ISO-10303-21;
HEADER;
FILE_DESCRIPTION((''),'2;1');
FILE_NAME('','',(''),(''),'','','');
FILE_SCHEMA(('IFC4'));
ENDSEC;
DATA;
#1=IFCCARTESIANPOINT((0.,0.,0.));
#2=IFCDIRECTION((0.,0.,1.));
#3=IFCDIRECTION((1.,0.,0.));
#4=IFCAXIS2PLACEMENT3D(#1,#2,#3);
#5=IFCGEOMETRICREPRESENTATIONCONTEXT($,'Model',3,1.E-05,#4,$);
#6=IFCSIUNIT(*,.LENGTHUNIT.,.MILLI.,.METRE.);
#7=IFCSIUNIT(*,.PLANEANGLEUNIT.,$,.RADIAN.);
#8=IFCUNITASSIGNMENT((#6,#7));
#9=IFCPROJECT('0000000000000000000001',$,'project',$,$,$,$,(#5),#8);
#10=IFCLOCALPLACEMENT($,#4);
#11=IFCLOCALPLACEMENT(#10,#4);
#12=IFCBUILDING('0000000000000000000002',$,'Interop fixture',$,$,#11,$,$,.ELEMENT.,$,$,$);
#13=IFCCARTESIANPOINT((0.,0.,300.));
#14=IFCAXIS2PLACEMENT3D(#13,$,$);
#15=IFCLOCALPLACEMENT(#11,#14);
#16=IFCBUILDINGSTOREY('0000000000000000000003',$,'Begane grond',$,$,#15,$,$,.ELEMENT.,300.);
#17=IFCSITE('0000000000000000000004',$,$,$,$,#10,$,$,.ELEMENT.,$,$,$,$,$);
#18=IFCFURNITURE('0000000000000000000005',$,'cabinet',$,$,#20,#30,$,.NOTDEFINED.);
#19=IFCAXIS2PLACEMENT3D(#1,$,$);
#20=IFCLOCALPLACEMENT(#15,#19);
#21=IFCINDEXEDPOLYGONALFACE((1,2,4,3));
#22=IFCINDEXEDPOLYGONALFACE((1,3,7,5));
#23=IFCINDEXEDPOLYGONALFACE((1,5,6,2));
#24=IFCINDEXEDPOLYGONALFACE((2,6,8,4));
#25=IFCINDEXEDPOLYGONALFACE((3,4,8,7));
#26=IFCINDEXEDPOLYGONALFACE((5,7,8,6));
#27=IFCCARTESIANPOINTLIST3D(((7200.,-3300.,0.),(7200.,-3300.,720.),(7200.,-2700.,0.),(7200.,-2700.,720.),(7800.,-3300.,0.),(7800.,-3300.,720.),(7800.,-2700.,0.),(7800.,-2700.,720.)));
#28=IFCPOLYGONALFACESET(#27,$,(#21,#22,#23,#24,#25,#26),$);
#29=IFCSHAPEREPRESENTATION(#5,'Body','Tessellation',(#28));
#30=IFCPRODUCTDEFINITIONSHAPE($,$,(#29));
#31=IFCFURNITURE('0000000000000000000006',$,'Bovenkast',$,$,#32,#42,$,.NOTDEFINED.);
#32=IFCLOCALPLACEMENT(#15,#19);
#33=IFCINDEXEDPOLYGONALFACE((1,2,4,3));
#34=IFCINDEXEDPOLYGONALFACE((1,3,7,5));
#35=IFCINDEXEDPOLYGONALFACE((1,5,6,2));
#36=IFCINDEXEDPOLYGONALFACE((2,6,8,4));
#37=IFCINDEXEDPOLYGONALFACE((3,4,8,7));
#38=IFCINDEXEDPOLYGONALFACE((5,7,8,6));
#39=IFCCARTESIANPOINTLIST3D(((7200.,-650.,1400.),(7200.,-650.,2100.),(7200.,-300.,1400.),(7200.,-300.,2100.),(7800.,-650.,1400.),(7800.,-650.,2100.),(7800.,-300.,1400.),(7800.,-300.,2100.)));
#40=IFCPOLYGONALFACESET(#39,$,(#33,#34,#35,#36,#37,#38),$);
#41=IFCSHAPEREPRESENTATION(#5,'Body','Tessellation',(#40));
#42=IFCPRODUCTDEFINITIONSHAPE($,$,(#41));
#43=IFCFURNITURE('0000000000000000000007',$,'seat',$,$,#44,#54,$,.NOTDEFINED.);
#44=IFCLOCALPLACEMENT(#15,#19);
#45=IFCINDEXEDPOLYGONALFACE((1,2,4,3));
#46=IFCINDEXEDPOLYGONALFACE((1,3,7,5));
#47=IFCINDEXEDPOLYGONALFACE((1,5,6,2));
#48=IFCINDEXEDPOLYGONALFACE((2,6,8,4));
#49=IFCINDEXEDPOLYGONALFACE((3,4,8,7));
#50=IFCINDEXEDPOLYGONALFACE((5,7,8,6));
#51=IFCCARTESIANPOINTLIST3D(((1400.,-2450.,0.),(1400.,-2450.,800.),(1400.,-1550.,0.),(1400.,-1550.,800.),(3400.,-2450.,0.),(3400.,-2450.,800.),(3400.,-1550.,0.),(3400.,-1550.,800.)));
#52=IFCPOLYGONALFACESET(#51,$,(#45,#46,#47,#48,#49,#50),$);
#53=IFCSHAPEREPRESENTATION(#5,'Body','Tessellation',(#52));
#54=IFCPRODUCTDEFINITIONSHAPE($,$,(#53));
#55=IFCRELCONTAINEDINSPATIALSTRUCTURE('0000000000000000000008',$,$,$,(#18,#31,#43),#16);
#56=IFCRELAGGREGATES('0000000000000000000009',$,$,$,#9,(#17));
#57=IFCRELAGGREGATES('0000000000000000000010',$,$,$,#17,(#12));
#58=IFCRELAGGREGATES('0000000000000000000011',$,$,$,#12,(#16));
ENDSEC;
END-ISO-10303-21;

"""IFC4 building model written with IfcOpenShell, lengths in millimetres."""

from ifc_helpers import new_model, si_unit, frame, origin, origin_with_axes, place, context, project, spatial, polyline, outline, extrude, element, save


model = new_model("IFC4")

# Units and contexts
model_context = context("Model", 3, precision=1e-05, world=origin_with_axes())
ifc_project = project(units=[si_unit("LENGTHUNIT", "METRE", prefix="MILLI"), si_unit("PLANEANGLEUNIT", "RADIAN")], contexts=[model_context])

# Site, building, storey
site_placement = place(None, origin_with_axes())
building_placement = place(site_placement, origin_with_axes())
storey_placement = place(building_placement, frame((0.0, 0.0, 300.0)))
placement = place(storey_placement, origin_with_axes())
site = spatial("IfcSite", under=ifc_project, at=site_placement, CompositionType="ELEMENT")
building = spatial("IfcBuilding", under=site, at=building_placement, Name="Interop fixture", CompositionType="ELEMENT")
storey = spatial("IfcBuildingStorey", under=building, at=storey_placement, Name="Begane grond", CompositionType="ELEMENT", Elevation=300.0)

# Furniture
element("IfcFurniture", 1, at=placement, inside=storey, Name="cabinet", PredefinedType="NOTDEFINED", context=model_context, shape_type="SweptSolid", body=[
    extrude(outline(polyline([(7200.0, -2700.0), (7800.0, -2700.0), (7800.0, -3300.0), (7200.0, -3300.0), (7200.0, -2700.0)])), origin(), (0.0, 0.0, 1.0), 720.0),
])
element("IfcFurniture", 2, at=placement, inside=storey, Name="Bovenkast", PredefinedType="NOTDEFINED", context=model_context, shape_type="SweptSolid", body=[
    extrude(outline(polyline([(7200.0, -300.0), (7800.0, -300.0), (7800.0, -650.0), (7200.0, -650.0), (7200.0, -300.0)])), frame((0.0, 0.0, 1400.0)), (0.0, 0.0, 1.0), 700.0),
])
element("IfcFurniture", 3, at=placement, inside=storey, Name="seat", PredefinedType="NOTDEFINED", context=model_context, shape_type="SweptSolid", body=[
    extrude(outline(polyline([(1400.0, -1550.0), (3400.0, -1550.0), (3400.0, -2450.0), (1400.0, -2450.0), (1400.0, -1550.0)])), origin(), (0.0, 0.0, 1.0), 800.0),
])

save(model, "model.ifc")
